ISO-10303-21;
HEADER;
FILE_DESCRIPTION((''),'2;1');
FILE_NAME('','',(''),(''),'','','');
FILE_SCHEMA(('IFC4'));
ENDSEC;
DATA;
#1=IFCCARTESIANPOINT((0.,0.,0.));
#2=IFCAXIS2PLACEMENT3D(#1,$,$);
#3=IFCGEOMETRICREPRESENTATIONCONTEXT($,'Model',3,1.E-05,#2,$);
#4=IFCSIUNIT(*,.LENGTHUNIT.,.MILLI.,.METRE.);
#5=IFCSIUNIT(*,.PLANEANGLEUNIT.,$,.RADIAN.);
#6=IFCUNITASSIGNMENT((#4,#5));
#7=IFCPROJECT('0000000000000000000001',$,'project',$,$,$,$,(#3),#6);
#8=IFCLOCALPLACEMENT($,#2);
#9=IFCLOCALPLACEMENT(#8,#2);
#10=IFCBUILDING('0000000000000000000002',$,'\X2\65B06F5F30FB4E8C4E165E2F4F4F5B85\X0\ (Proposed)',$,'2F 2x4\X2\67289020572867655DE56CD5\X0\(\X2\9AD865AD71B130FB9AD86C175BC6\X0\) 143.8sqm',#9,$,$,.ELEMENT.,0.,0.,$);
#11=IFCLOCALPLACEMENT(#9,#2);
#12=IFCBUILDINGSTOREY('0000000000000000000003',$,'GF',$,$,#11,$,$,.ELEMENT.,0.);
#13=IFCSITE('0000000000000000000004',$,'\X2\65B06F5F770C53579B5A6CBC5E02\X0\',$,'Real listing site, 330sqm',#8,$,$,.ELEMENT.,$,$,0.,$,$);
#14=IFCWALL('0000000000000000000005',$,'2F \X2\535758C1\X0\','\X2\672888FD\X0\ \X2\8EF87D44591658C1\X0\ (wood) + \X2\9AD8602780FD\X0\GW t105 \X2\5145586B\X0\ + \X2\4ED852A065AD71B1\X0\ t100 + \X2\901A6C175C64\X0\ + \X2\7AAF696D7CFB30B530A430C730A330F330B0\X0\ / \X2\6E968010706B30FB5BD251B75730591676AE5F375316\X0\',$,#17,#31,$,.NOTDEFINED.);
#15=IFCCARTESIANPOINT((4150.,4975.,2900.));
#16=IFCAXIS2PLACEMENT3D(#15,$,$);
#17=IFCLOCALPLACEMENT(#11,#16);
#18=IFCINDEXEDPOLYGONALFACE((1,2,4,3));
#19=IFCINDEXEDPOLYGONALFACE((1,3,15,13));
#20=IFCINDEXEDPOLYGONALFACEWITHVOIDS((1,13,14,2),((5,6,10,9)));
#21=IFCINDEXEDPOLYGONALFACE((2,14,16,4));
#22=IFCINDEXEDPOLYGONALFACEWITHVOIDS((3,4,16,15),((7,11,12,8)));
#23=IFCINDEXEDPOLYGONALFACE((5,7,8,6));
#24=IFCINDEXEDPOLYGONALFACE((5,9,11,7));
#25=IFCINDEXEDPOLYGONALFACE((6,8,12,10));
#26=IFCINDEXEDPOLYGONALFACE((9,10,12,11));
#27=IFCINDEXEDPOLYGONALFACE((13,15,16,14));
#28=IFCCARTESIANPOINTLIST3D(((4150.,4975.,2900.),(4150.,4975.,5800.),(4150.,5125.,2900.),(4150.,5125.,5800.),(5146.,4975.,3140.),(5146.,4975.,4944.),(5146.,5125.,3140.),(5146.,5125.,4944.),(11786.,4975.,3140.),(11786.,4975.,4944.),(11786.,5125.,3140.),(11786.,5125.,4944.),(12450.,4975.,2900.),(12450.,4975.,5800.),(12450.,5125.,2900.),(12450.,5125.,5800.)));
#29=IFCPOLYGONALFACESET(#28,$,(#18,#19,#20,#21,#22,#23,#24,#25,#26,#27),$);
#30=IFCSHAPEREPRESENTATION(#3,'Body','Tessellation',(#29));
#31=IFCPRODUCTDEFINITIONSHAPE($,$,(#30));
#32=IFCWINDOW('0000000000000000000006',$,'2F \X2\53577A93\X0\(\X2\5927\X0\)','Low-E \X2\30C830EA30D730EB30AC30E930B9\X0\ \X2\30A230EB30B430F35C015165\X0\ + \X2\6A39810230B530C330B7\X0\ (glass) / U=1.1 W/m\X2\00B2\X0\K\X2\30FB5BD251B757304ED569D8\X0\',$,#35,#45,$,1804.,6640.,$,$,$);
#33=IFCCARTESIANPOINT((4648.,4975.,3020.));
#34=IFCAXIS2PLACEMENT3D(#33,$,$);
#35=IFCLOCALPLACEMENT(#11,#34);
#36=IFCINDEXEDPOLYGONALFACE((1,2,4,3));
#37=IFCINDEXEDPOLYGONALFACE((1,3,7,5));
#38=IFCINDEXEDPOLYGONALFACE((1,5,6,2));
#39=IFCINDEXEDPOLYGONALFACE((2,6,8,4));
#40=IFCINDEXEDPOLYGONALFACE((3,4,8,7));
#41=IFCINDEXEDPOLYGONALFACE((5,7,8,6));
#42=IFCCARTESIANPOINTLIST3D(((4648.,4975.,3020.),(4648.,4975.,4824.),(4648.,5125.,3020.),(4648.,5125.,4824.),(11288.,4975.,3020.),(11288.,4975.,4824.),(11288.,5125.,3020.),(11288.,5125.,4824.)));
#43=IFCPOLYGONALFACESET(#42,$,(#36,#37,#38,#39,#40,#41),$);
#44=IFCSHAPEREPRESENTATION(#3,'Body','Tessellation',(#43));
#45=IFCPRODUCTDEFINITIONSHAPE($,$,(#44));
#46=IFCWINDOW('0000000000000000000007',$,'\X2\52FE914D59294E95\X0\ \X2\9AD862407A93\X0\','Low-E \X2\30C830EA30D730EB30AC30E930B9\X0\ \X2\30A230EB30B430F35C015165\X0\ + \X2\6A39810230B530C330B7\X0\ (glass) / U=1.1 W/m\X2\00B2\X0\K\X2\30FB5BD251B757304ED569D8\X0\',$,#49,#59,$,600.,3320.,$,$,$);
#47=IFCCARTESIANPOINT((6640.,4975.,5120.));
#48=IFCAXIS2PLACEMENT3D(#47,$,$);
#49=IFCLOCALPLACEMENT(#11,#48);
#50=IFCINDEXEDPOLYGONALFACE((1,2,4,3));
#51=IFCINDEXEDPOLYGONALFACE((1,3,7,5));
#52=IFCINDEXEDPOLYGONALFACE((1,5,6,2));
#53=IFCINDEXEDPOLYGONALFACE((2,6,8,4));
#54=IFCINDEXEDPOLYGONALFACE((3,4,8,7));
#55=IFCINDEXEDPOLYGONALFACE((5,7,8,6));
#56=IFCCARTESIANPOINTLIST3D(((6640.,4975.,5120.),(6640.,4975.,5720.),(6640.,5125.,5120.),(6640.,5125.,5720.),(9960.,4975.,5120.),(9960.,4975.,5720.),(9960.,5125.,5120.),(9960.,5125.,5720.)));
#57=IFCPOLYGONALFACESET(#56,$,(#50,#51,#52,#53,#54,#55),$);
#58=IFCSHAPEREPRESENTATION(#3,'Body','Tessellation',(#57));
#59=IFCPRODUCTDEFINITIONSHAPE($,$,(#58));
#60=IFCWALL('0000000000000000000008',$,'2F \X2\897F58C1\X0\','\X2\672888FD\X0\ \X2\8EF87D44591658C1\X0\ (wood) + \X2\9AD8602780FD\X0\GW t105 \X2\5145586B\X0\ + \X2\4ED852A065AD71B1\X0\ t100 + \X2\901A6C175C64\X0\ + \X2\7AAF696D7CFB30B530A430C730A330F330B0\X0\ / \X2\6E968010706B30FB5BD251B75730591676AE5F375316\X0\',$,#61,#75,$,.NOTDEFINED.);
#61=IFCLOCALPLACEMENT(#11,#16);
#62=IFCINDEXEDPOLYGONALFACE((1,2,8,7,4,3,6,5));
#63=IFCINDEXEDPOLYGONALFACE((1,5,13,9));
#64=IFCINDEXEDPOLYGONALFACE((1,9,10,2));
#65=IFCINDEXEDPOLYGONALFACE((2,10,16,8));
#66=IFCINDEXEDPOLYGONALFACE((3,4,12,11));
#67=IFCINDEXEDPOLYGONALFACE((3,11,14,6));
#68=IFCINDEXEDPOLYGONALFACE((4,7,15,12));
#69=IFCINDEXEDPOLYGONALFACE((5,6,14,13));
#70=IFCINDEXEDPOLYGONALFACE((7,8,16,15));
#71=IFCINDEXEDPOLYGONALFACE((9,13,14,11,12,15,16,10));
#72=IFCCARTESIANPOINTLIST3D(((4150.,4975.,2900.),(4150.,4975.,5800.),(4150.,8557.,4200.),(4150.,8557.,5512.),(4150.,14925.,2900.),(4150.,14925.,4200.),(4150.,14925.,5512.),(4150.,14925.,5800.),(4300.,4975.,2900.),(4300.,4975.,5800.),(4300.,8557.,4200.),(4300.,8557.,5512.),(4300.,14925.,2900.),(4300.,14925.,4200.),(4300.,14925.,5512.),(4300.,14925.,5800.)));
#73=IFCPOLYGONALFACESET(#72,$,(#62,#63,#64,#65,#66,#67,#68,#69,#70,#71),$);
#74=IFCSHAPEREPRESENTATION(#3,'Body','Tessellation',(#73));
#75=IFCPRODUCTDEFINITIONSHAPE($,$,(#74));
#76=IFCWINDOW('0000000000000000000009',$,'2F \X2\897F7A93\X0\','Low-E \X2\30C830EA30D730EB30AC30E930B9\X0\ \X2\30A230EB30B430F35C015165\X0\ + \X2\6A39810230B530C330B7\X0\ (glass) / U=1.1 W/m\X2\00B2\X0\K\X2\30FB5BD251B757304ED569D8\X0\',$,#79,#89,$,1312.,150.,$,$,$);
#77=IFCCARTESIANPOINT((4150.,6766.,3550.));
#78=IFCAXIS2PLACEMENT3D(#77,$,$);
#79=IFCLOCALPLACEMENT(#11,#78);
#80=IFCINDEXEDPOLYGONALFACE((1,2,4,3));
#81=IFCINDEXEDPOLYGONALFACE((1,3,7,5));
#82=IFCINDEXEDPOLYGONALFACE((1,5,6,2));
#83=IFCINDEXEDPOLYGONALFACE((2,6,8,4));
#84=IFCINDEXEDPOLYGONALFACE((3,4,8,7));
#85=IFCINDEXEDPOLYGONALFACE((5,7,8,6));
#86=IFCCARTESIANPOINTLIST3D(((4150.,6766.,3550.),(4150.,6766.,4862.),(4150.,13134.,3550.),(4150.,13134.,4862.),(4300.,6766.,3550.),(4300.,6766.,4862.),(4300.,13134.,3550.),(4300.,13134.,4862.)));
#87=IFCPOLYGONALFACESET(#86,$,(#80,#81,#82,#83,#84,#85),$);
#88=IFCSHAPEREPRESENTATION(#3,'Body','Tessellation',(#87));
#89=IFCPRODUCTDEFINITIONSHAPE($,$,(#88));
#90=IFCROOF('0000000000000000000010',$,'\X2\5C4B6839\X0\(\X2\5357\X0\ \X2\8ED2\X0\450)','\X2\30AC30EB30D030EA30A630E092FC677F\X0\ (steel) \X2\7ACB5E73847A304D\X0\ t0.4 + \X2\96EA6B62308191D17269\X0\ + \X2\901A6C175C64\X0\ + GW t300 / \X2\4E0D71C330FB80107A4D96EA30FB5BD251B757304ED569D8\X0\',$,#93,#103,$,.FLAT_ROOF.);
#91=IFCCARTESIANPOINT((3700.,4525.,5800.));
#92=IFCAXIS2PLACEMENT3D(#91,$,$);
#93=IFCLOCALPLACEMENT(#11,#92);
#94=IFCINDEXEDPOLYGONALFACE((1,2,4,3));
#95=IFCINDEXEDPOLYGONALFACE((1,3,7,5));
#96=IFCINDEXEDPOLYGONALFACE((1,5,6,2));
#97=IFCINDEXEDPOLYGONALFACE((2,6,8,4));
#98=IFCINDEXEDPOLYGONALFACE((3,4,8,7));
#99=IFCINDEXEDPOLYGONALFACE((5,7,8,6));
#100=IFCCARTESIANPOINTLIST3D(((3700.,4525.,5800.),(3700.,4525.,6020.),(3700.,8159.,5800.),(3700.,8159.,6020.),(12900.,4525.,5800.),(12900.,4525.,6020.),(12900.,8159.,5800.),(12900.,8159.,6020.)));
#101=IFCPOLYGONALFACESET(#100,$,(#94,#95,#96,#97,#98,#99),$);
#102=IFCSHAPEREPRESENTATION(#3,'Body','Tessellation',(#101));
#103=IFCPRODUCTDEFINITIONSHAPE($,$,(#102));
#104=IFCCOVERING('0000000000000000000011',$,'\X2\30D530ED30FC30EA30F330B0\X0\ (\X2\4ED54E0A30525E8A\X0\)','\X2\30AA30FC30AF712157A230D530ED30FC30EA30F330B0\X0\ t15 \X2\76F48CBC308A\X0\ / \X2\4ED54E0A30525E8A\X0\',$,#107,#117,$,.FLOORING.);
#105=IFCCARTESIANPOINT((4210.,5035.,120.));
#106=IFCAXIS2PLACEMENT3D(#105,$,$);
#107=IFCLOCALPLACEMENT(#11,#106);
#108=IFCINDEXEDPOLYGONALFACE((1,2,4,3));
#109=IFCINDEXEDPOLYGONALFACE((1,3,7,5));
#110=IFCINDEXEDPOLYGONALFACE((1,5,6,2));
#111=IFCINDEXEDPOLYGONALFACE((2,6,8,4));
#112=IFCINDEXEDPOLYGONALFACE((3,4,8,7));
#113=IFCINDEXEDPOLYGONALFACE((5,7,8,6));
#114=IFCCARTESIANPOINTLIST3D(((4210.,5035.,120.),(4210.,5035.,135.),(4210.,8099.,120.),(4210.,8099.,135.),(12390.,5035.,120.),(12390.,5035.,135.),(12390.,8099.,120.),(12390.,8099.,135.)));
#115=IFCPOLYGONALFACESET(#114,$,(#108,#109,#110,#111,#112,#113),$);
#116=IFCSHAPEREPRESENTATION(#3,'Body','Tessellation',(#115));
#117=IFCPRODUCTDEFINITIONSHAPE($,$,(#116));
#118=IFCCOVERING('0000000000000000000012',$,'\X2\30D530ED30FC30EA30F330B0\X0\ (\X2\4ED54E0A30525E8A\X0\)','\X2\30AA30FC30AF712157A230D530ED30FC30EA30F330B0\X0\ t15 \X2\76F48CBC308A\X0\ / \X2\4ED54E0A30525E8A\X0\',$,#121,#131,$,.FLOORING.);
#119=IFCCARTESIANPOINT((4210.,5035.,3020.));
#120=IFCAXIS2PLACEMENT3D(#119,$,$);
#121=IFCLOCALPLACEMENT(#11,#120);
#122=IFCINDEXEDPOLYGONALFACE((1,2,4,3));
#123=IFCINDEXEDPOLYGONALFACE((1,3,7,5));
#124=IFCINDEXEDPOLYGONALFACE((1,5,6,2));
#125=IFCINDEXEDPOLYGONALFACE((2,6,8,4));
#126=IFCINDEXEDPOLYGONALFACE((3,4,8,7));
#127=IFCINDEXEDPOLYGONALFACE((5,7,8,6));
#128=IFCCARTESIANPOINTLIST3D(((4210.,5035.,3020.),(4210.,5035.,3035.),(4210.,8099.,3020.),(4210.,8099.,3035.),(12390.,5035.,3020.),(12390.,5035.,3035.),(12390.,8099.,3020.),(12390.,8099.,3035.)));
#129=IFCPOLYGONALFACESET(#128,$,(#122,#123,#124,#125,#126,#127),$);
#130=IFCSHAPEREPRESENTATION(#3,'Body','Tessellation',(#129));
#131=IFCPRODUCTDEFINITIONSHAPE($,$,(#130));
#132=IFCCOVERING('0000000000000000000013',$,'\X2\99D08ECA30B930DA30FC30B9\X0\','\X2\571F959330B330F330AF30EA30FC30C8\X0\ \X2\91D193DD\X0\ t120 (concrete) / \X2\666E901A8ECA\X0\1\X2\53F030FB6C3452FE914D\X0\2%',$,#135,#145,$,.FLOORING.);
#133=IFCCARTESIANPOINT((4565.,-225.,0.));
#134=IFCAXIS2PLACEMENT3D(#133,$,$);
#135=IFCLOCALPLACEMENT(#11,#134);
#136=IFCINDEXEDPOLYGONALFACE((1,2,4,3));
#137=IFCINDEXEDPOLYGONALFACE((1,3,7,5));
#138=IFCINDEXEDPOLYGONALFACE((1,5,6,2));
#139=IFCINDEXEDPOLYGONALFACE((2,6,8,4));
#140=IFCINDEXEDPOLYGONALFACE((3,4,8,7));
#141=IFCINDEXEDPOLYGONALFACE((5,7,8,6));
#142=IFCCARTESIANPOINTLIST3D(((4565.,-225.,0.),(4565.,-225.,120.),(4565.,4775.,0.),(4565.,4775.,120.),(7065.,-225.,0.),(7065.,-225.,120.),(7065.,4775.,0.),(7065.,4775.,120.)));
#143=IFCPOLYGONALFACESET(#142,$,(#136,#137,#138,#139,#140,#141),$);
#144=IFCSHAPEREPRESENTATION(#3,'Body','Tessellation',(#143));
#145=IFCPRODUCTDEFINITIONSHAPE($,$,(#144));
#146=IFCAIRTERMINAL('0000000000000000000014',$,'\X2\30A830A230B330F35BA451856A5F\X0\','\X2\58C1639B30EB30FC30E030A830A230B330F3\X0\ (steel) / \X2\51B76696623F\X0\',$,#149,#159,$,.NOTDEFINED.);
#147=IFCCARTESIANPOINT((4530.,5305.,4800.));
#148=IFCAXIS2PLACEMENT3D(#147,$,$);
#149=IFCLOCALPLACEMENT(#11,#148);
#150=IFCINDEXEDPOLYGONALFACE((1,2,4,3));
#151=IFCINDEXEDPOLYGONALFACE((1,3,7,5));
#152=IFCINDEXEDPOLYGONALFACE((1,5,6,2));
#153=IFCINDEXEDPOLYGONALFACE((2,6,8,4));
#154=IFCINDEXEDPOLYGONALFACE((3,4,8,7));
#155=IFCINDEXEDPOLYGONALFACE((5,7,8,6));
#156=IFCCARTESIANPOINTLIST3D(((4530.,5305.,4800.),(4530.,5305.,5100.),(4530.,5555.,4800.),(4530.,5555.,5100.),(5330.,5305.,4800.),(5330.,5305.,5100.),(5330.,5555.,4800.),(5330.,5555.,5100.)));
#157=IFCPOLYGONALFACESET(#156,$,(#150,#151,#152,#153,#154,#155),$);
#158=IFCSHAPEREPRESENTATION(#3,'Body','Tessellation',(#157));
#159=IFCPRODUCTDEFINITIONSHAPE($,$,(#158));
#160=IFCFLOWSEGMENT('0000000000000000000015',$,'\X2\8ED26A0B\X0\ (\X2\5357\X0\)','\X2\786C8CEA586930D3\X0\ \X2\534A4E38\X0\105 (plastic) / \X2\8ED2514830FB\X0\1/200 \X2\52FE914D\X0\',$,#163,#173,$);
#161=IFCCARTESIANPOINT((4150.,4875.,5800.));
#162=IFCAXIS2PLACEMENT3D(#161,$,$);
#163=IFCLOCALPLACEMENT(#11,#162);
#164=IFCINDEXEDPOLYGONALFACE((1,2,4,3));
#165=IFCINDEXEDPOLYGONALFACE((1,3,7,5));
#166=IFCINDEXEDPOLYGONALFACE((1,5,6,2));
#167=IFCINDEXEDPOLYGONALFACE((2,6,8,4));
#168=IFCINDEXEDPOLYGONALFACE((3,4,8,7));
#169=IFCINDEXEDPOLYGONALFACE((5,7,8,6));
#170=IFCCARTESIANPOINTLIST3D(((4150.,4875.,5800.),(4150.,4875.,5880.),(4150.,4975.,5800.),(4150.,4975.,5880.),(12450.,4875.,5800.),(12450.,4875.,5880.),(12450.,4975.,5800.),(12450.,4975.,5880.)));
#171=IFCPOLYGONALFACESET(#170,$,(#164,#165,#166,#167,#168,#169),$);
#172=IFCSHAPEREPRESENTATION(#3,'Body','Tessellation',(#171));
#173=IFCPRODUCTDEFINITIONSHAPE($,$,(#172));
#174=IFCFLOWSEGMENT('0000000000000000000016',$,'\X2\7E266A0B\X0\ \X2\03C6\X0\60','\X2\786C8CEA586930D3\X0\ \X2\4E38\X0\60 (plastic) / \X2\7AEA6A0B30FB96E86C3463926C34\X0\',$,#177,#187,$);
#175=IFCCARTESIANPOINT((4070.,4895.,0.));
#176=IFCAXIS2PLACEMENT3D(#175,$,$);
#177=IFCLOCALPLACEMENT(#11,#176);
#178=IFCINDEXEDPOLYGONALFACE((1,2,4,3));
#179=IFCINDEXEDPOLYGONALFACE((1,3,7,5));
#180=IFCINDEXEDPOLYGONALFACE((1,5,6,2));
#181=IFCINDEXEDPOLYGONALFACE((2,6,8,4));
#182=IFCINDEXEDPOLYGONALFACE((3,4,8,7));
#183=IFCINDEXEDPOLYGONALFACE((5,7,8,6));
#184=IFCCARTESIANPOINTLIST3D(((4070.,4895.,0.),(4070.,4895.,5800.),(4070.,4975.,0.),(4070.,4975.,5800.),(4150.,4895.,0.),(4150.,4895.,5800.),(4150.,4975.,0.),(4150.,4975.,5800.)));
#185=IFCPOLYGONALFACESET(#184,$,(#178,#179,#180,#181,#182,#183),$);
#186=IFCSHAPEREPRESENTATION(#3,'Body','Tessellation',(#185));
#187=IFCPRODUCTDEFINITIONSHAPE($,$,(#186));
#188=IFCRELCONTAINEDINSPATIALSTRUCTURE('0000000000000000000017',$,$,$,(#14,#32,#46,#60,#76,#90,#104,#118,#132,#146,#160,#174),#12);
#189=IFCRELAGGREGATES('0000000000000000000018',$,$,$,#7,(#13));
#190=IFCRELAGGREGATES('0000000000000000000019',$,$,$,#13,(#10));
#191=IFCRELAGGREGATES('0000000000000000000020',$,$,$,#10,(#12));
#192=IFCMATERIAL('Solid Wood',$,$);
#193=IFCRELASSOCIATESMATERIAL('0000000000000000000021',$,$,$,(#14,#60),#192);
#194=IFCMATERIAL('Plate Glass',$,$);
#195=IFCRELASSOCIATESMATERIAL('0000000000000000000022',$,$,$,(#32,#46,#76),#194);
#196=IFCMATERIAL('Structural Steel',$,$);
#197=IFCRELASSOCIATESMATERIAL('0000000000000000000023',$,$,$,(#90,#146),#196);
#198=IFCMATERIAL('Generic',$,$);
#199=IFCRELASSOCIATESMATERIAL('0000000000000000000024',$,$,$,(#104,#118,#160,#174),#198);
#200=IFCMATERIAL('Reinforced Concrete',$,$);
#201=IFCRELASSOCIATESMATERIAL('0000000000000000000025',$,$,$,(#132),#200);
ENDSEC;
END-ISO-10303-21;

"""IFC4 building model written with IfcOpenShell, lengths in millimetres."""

from ifc_helpers import new_model, si_unit, frame, frame_2d, origin, place, context, project, spatial, rectangle, extrude, material, element, fill, save


model = new_model("IFC4")

# Units and contexts
model_context = context("Model", 3, precision=1e-05, world=origin())
ifc_project = project(units=[si_unit("LENGTHUNIT", "METRE", prefix="MILLI"), si_unit("PLANEANGLEUNIT", "RADIAN")], contexts=[model_context])

# Site, building, storey
site_placement = place(None, origin())
site = spatial("IfcSite", under=ifc_project, at=site_placement, Name="新潟県南魚沼市", ObjectType="Real listing site, 330sqm", CompositionType="ELEMENT", RefElevation=0.0)
building_placement = place(site_placement, origin())
building = spatial("IfcBuilding", under=site, at=building_placement, Name="新潟・二世帯住宅 (Proposed)", ObjectType="2F 2x4木造在来工法(高断熱・高気密) 143.8sqm", CompositionType="ELEMENT", ElevationOfRefHeight=0.0, ElevationOfTerrain=0.0)
storey_placement = place(building_placement, origin())
storey = spatial("IfcBuildingStorey", under=building, at=storey_placement, Name="GF", CompositionType="ELEMENT", Elevation=0.0)

# Shared definitions
ifc_material_1 = material(Name="Solid Wood")

# Shared definitions
ifc_material_2 = material(Name="Reinforced Concrete")

# Shared definitions
ifc_material_3 = material(Name="Plate Glass")

# Wall, openings, windows
wall_1_placement = place(storey_placement, frame((4150.0, 4975.0, 2900.0)))
wall_1 = element("IfcWall", 1, at=wall_1_placement, inside=storey, material=ifc_material_1, Name="2F 南壁", Description="木製 軸組外壁 (wood) + 高性能GW t105 充填 + 付加断熱 t100 + 通気層 + 窯業系サイディング / 準耐火・寒冷地外皮強化", PredefinedType="NOTDEFINED", context=model_context, shape_type="SweptSolid", body=[
    extrude(rectangle(XDim=8300.0, YDim=150.0, at=frame_2d((4150.0, 75.0))), frame((4150.0, 4975.0, 2900.0)), (0.0, 0.0, 1.0), 2900.0),
])
opening_1_placement = place(storey_placement, frame((4648.0, 4975.0, 3020.0)))
opening_1 = element("IfcOpeningElement", 2, at=opening_1_placement, cuts=wall_1, PredefinedType="NOTDEFINED", context=model_context, shape_type="SweptSolid", body=[
    extrude(rectangle(XDim=6640.0, YDim=150.0, at=frame_2d((3320.0, 75.0))), frame((4648.0, 4975.0, 3020.0)), (0.0, 0.0, 1.0), 1804.0),
])
opening_2_placement = place(storey_placement, frame((6640.0, 4975.0, 5120.0)))
opening_2 = element("IfcOpeningElement", 3, at=opening_2_placement, cuts=wall_1, PredefinedType="NOTDEFINED", context=model_context, shape_type="SweptSolid", body=[
    extrude(rectangle(XDim=3320.0, YDim=150.0, at=frame_2d((1660.0, 75.0))), frame((6640.0, 4975.0, 5120.0)), (0.0, 0.0, 1.0), 600.0),
])
window_1_placement = place(storey_placement, frame((4648.0, 4975.0, 3020.0)))
window_1 = element("IfcWindow", 4, at=window_1_placement, inside=storey, material=ifc_material_3, Name="2F 南窓(大)", Description="Low-E トリプルガラス アルゴン封入 + 樹脂サッシ (glass) / U=1.1 W/m²K・寒冷地仕様", OverallHeight=1804.0, OverallWidth=6640.0, context=model_context, shape_type="SweptSolid", body=[
    extrude(rectangle(XDim=6640.0, YDim=150.0, at=frame_2d((3320.0, 75.0))), frame((4648.0, 4975.0, 3020.0)), (0.0, 0.0, 1.0), 1804.0),
])
fill(opening_1, window_1)
window_2_placement = place(storey_placement, frame((6640.0, 4975.0, 5120.0)))
window_2 = element("IfcWindow", 5, at=window_2_placement, inside=storey, material=ifc_material_3, Name="勾配天井 高所窓", Description="Low-E トリプルガラス アルゴン封入 + 樹脂サッシ (glass) / U=1.1 W/m²K・寒冷地仕様", OverallHeight=600.0, OverallWidth=3320.0, context=model_context, shape_type="SweptSolid", body=[
    extrude(rectangle(XDim=3320.0, YDim=150.0, at=frame_2d((1660.0, 75.0))), frame((6640.0, 4975.0, 5120.0)), (0.0, 0.0, 1.0), 600.0),
])
fill(opening_2, window_2)

# Wall, opening, window
wall_2_placement = place(storey_placement, frame((4150.0, 4975.0, 2900.0)))
wall_2 = element("IfcWall", 6, at=wall_2_placement, inside=storey, material=ifc_material_1, Name="2F 西壁", Description="木製 軸組外壁 (wood) + 高性能GW t105 充填 + 付加断熱 t100 + 通気層 + 窯業系サイディング / 準耐火・寒冷地外皮強化", PredefinedType="NOTDEFINED", context=model_context, shape_type="SweptSolid", body=[
    extrude(rectangle(XDim=150.0, YDim=9950.0, at=frame_2d((75.0, 4975.0))), frame((4150.0, 4975.0, 2900.0)), (0.0, 0.0, 1.0), 2900.0),
])
opening_3_placement = place(storey_placement, frame((4150.0, 6766.0, 3550.0)))
opening_3 = element("IfcOpeningElement", 7, at=opening_3_placement, cuts=wall_2, PredefinedType="NOTDEFINED", context=model_context, shape_type="SweptSolid", body=[
    extrude(rectangle(XDim=150.0, YDim=6368.0, at=frame_2d((75.0, 3184.0))), frame((4150.0, 6766.0, 3550.0)), (0.0, 0.0, 1.0), 1312.0),
])
window_3_placement = place(storey_placement, frame((4150.0, 6766.0, 3550.0)))
window_3 = element("IfcWindow", 8, at=window_3_placement, inside=storey, material=ifc_material_3, Name="2F 西窓", Description="Low-E トリプルガラス アルゴン封入 + 樹脂サッシ (glass) / U=1.1 W/m²K・寒冷地仕様", OverallHeight=1312.0, OverallWidth=150.0, context=model_context, shape_type="SweptSolid", body=[
    extrude(rectangle(XDim=150.0, YDim=6368.0, at=frame_2d((75.0, 3184.0))), frame((4150.0, 6766.0, 3550.0)), (0.0, 0.0, 1.0), 1312.0),
])
fill(opening_3, window_3)

# Roof
ifc_material_4 = material(Name="Structural Steel")
for number, where, name in (
    (9, (3700.0, 4525.0, 5800.0), "屋根(南 軒450)"),
):
    element("IfcRoof", number, at=place(storey_placement, frame(where)), inside=storey, material=ifc_material_4, Name=name, Description="ガルバリウム鋼板 (steel) 立平葺き t0.4 + 雪止め金物 + 通気層 + GW t300 / 不燃・耐積雪・寒冷地仕様", PredefinedType="FLAT_ROOF", context=model_context, shape_type="SweptSolid", body=[
        extrude(rectangle(XDim=9200.0, YDim=3634.0, at=frame_2d((4600.0, 1817.0))), frame((3700.0, 4525.0, 5800.0)), (0.0, 0.0, 1.0), 220.0),
    ])

# Coverings
ifc_material_5 = material(Name="Generic")
covering_1_placement = place(storey_placement, frame((4210.0, 5035.0, 120.0)))
element("IfcCovering", 10, at=covering_1_placement, inside=storey, material=ifc_material_5, Name="フローリング (仕上げ床)", Description="オーク無垢フローリング t15 直貼り / 仕上げ床", PredefinedType="FLOORING", context=model_context, shape_type="SweptSolid", body=[
    extrude(rectangle(XDim=8180.0, YDim=3064.0, at=frame_2d((4090.0, 1532.0))), frame((4210.0, 5035.0, 120.0)), (0.0, 0.0, 1.0), 15.0),
])
covering_2_placement = place(storey_placement, frame((4210.0, 5035.0, 3020.0)))
element("IfcCovering", 11, at=covering_2_placement, inside=storey, material=ifc_material_5, Name="フローリング (仕上げ床)", Description="オーク無垢フローリング t15 直貼り / 仕上げ床", PredefinedType="FLOORING", context=model_context, shape_type="SweptSolid", body=[
    extrude(rectangle(XDim=8180.0, YDim=3064.0, at=frame_2d((4090.0, 1532.0))), frame((4210.0, 5035.0, 3020.0)), (0.0, 0.0, 1.0), 15.0),
])
covering_3_placement = place(storey_placement, frame((4565.0, -225.0, 0.0)))
element("IfcCovering", 12, at=covering_3_placement, inside=storey, material=ifc_material_2, Name="駐車スペース", Description="土間コンクリート 金鏝 t120 (concrete) / 普通車1台・水勾配2%", PredefinedType="FLOORING", context=model_context, shape_type="SweptSolid", body=[
    extrude(rectangle(XDim=2500.0, YDim=5000.0, at=frame_2d((1250.0, 2500.0))), frame((4565.0, -225.0, 0.0)), (0.0, 0.0, 1.0), 120.0),
])

# Air terminal
air_terminal_placement = place(storey_placement, frame((4530.0, 5305.0, 4800.0)))
element("IfcAirTerminal", 13, at=air_terminal_placement, inside=storey, material=ifc_material_4, Name="エアコン室内機", Description="壁掛ルームエアコン (steel) / 冷暖房", PredefinedType="NOTDEFINED", context=model_context, shape_type="SweptSolid", body=[
    extrude(rectangle(XDim=800.0, YDim=250.0, at=frame_2d((400.0, 125.0))), frame((4530.0, 5305.0, 4800.0)), (0.0, 0.0, 1.0), 300.0),
])

# Flow segments
flow_segment_1_placement = place(storey_placement, frame((4150.0, 4875.0, 5800.0)))
element("IfcFlowSegment", 14, at=flow_segment_1_placement, inside=storey, material=ifc_material_5, Name="軒樋 (南)", Description="硬質塩ビ 半丸105 (plastic) / 軒先・1/200 勾配", context=model_context, shape_type="SweptSolid", body=[
    extrude(rectangle(XDim=8300.0, YDim=100.0, at=frame_2d((4150.0, 50.0))), frame((4150.0, 4875.0, 5800.0)), (0.0, 0.0, 1.0), 80.0),
])
flow_segment_2_placement = place(storey_placement, frame((4070.0, 4895.0, 0.0)))
element("IfcFlowSegment", 15, at=flow_segment_2_placement, inside=storey, material=ifc_material_5, Name="縦樋 φ60", Description="硬質塩ビ 丸60 (plastic) / 竪樋・雨水排水", context=model_context, shape_type="SweptSolid", body=[
    extrude(rectangle(XDim=80.0, YDim=80.0, at=frame_2d((40.0, 40.0))), frame((4070.0, 4895.0, 0.0)), (0.0, 0.0, 1.0), 5800.0),
])

save(model, "model.ifc")
